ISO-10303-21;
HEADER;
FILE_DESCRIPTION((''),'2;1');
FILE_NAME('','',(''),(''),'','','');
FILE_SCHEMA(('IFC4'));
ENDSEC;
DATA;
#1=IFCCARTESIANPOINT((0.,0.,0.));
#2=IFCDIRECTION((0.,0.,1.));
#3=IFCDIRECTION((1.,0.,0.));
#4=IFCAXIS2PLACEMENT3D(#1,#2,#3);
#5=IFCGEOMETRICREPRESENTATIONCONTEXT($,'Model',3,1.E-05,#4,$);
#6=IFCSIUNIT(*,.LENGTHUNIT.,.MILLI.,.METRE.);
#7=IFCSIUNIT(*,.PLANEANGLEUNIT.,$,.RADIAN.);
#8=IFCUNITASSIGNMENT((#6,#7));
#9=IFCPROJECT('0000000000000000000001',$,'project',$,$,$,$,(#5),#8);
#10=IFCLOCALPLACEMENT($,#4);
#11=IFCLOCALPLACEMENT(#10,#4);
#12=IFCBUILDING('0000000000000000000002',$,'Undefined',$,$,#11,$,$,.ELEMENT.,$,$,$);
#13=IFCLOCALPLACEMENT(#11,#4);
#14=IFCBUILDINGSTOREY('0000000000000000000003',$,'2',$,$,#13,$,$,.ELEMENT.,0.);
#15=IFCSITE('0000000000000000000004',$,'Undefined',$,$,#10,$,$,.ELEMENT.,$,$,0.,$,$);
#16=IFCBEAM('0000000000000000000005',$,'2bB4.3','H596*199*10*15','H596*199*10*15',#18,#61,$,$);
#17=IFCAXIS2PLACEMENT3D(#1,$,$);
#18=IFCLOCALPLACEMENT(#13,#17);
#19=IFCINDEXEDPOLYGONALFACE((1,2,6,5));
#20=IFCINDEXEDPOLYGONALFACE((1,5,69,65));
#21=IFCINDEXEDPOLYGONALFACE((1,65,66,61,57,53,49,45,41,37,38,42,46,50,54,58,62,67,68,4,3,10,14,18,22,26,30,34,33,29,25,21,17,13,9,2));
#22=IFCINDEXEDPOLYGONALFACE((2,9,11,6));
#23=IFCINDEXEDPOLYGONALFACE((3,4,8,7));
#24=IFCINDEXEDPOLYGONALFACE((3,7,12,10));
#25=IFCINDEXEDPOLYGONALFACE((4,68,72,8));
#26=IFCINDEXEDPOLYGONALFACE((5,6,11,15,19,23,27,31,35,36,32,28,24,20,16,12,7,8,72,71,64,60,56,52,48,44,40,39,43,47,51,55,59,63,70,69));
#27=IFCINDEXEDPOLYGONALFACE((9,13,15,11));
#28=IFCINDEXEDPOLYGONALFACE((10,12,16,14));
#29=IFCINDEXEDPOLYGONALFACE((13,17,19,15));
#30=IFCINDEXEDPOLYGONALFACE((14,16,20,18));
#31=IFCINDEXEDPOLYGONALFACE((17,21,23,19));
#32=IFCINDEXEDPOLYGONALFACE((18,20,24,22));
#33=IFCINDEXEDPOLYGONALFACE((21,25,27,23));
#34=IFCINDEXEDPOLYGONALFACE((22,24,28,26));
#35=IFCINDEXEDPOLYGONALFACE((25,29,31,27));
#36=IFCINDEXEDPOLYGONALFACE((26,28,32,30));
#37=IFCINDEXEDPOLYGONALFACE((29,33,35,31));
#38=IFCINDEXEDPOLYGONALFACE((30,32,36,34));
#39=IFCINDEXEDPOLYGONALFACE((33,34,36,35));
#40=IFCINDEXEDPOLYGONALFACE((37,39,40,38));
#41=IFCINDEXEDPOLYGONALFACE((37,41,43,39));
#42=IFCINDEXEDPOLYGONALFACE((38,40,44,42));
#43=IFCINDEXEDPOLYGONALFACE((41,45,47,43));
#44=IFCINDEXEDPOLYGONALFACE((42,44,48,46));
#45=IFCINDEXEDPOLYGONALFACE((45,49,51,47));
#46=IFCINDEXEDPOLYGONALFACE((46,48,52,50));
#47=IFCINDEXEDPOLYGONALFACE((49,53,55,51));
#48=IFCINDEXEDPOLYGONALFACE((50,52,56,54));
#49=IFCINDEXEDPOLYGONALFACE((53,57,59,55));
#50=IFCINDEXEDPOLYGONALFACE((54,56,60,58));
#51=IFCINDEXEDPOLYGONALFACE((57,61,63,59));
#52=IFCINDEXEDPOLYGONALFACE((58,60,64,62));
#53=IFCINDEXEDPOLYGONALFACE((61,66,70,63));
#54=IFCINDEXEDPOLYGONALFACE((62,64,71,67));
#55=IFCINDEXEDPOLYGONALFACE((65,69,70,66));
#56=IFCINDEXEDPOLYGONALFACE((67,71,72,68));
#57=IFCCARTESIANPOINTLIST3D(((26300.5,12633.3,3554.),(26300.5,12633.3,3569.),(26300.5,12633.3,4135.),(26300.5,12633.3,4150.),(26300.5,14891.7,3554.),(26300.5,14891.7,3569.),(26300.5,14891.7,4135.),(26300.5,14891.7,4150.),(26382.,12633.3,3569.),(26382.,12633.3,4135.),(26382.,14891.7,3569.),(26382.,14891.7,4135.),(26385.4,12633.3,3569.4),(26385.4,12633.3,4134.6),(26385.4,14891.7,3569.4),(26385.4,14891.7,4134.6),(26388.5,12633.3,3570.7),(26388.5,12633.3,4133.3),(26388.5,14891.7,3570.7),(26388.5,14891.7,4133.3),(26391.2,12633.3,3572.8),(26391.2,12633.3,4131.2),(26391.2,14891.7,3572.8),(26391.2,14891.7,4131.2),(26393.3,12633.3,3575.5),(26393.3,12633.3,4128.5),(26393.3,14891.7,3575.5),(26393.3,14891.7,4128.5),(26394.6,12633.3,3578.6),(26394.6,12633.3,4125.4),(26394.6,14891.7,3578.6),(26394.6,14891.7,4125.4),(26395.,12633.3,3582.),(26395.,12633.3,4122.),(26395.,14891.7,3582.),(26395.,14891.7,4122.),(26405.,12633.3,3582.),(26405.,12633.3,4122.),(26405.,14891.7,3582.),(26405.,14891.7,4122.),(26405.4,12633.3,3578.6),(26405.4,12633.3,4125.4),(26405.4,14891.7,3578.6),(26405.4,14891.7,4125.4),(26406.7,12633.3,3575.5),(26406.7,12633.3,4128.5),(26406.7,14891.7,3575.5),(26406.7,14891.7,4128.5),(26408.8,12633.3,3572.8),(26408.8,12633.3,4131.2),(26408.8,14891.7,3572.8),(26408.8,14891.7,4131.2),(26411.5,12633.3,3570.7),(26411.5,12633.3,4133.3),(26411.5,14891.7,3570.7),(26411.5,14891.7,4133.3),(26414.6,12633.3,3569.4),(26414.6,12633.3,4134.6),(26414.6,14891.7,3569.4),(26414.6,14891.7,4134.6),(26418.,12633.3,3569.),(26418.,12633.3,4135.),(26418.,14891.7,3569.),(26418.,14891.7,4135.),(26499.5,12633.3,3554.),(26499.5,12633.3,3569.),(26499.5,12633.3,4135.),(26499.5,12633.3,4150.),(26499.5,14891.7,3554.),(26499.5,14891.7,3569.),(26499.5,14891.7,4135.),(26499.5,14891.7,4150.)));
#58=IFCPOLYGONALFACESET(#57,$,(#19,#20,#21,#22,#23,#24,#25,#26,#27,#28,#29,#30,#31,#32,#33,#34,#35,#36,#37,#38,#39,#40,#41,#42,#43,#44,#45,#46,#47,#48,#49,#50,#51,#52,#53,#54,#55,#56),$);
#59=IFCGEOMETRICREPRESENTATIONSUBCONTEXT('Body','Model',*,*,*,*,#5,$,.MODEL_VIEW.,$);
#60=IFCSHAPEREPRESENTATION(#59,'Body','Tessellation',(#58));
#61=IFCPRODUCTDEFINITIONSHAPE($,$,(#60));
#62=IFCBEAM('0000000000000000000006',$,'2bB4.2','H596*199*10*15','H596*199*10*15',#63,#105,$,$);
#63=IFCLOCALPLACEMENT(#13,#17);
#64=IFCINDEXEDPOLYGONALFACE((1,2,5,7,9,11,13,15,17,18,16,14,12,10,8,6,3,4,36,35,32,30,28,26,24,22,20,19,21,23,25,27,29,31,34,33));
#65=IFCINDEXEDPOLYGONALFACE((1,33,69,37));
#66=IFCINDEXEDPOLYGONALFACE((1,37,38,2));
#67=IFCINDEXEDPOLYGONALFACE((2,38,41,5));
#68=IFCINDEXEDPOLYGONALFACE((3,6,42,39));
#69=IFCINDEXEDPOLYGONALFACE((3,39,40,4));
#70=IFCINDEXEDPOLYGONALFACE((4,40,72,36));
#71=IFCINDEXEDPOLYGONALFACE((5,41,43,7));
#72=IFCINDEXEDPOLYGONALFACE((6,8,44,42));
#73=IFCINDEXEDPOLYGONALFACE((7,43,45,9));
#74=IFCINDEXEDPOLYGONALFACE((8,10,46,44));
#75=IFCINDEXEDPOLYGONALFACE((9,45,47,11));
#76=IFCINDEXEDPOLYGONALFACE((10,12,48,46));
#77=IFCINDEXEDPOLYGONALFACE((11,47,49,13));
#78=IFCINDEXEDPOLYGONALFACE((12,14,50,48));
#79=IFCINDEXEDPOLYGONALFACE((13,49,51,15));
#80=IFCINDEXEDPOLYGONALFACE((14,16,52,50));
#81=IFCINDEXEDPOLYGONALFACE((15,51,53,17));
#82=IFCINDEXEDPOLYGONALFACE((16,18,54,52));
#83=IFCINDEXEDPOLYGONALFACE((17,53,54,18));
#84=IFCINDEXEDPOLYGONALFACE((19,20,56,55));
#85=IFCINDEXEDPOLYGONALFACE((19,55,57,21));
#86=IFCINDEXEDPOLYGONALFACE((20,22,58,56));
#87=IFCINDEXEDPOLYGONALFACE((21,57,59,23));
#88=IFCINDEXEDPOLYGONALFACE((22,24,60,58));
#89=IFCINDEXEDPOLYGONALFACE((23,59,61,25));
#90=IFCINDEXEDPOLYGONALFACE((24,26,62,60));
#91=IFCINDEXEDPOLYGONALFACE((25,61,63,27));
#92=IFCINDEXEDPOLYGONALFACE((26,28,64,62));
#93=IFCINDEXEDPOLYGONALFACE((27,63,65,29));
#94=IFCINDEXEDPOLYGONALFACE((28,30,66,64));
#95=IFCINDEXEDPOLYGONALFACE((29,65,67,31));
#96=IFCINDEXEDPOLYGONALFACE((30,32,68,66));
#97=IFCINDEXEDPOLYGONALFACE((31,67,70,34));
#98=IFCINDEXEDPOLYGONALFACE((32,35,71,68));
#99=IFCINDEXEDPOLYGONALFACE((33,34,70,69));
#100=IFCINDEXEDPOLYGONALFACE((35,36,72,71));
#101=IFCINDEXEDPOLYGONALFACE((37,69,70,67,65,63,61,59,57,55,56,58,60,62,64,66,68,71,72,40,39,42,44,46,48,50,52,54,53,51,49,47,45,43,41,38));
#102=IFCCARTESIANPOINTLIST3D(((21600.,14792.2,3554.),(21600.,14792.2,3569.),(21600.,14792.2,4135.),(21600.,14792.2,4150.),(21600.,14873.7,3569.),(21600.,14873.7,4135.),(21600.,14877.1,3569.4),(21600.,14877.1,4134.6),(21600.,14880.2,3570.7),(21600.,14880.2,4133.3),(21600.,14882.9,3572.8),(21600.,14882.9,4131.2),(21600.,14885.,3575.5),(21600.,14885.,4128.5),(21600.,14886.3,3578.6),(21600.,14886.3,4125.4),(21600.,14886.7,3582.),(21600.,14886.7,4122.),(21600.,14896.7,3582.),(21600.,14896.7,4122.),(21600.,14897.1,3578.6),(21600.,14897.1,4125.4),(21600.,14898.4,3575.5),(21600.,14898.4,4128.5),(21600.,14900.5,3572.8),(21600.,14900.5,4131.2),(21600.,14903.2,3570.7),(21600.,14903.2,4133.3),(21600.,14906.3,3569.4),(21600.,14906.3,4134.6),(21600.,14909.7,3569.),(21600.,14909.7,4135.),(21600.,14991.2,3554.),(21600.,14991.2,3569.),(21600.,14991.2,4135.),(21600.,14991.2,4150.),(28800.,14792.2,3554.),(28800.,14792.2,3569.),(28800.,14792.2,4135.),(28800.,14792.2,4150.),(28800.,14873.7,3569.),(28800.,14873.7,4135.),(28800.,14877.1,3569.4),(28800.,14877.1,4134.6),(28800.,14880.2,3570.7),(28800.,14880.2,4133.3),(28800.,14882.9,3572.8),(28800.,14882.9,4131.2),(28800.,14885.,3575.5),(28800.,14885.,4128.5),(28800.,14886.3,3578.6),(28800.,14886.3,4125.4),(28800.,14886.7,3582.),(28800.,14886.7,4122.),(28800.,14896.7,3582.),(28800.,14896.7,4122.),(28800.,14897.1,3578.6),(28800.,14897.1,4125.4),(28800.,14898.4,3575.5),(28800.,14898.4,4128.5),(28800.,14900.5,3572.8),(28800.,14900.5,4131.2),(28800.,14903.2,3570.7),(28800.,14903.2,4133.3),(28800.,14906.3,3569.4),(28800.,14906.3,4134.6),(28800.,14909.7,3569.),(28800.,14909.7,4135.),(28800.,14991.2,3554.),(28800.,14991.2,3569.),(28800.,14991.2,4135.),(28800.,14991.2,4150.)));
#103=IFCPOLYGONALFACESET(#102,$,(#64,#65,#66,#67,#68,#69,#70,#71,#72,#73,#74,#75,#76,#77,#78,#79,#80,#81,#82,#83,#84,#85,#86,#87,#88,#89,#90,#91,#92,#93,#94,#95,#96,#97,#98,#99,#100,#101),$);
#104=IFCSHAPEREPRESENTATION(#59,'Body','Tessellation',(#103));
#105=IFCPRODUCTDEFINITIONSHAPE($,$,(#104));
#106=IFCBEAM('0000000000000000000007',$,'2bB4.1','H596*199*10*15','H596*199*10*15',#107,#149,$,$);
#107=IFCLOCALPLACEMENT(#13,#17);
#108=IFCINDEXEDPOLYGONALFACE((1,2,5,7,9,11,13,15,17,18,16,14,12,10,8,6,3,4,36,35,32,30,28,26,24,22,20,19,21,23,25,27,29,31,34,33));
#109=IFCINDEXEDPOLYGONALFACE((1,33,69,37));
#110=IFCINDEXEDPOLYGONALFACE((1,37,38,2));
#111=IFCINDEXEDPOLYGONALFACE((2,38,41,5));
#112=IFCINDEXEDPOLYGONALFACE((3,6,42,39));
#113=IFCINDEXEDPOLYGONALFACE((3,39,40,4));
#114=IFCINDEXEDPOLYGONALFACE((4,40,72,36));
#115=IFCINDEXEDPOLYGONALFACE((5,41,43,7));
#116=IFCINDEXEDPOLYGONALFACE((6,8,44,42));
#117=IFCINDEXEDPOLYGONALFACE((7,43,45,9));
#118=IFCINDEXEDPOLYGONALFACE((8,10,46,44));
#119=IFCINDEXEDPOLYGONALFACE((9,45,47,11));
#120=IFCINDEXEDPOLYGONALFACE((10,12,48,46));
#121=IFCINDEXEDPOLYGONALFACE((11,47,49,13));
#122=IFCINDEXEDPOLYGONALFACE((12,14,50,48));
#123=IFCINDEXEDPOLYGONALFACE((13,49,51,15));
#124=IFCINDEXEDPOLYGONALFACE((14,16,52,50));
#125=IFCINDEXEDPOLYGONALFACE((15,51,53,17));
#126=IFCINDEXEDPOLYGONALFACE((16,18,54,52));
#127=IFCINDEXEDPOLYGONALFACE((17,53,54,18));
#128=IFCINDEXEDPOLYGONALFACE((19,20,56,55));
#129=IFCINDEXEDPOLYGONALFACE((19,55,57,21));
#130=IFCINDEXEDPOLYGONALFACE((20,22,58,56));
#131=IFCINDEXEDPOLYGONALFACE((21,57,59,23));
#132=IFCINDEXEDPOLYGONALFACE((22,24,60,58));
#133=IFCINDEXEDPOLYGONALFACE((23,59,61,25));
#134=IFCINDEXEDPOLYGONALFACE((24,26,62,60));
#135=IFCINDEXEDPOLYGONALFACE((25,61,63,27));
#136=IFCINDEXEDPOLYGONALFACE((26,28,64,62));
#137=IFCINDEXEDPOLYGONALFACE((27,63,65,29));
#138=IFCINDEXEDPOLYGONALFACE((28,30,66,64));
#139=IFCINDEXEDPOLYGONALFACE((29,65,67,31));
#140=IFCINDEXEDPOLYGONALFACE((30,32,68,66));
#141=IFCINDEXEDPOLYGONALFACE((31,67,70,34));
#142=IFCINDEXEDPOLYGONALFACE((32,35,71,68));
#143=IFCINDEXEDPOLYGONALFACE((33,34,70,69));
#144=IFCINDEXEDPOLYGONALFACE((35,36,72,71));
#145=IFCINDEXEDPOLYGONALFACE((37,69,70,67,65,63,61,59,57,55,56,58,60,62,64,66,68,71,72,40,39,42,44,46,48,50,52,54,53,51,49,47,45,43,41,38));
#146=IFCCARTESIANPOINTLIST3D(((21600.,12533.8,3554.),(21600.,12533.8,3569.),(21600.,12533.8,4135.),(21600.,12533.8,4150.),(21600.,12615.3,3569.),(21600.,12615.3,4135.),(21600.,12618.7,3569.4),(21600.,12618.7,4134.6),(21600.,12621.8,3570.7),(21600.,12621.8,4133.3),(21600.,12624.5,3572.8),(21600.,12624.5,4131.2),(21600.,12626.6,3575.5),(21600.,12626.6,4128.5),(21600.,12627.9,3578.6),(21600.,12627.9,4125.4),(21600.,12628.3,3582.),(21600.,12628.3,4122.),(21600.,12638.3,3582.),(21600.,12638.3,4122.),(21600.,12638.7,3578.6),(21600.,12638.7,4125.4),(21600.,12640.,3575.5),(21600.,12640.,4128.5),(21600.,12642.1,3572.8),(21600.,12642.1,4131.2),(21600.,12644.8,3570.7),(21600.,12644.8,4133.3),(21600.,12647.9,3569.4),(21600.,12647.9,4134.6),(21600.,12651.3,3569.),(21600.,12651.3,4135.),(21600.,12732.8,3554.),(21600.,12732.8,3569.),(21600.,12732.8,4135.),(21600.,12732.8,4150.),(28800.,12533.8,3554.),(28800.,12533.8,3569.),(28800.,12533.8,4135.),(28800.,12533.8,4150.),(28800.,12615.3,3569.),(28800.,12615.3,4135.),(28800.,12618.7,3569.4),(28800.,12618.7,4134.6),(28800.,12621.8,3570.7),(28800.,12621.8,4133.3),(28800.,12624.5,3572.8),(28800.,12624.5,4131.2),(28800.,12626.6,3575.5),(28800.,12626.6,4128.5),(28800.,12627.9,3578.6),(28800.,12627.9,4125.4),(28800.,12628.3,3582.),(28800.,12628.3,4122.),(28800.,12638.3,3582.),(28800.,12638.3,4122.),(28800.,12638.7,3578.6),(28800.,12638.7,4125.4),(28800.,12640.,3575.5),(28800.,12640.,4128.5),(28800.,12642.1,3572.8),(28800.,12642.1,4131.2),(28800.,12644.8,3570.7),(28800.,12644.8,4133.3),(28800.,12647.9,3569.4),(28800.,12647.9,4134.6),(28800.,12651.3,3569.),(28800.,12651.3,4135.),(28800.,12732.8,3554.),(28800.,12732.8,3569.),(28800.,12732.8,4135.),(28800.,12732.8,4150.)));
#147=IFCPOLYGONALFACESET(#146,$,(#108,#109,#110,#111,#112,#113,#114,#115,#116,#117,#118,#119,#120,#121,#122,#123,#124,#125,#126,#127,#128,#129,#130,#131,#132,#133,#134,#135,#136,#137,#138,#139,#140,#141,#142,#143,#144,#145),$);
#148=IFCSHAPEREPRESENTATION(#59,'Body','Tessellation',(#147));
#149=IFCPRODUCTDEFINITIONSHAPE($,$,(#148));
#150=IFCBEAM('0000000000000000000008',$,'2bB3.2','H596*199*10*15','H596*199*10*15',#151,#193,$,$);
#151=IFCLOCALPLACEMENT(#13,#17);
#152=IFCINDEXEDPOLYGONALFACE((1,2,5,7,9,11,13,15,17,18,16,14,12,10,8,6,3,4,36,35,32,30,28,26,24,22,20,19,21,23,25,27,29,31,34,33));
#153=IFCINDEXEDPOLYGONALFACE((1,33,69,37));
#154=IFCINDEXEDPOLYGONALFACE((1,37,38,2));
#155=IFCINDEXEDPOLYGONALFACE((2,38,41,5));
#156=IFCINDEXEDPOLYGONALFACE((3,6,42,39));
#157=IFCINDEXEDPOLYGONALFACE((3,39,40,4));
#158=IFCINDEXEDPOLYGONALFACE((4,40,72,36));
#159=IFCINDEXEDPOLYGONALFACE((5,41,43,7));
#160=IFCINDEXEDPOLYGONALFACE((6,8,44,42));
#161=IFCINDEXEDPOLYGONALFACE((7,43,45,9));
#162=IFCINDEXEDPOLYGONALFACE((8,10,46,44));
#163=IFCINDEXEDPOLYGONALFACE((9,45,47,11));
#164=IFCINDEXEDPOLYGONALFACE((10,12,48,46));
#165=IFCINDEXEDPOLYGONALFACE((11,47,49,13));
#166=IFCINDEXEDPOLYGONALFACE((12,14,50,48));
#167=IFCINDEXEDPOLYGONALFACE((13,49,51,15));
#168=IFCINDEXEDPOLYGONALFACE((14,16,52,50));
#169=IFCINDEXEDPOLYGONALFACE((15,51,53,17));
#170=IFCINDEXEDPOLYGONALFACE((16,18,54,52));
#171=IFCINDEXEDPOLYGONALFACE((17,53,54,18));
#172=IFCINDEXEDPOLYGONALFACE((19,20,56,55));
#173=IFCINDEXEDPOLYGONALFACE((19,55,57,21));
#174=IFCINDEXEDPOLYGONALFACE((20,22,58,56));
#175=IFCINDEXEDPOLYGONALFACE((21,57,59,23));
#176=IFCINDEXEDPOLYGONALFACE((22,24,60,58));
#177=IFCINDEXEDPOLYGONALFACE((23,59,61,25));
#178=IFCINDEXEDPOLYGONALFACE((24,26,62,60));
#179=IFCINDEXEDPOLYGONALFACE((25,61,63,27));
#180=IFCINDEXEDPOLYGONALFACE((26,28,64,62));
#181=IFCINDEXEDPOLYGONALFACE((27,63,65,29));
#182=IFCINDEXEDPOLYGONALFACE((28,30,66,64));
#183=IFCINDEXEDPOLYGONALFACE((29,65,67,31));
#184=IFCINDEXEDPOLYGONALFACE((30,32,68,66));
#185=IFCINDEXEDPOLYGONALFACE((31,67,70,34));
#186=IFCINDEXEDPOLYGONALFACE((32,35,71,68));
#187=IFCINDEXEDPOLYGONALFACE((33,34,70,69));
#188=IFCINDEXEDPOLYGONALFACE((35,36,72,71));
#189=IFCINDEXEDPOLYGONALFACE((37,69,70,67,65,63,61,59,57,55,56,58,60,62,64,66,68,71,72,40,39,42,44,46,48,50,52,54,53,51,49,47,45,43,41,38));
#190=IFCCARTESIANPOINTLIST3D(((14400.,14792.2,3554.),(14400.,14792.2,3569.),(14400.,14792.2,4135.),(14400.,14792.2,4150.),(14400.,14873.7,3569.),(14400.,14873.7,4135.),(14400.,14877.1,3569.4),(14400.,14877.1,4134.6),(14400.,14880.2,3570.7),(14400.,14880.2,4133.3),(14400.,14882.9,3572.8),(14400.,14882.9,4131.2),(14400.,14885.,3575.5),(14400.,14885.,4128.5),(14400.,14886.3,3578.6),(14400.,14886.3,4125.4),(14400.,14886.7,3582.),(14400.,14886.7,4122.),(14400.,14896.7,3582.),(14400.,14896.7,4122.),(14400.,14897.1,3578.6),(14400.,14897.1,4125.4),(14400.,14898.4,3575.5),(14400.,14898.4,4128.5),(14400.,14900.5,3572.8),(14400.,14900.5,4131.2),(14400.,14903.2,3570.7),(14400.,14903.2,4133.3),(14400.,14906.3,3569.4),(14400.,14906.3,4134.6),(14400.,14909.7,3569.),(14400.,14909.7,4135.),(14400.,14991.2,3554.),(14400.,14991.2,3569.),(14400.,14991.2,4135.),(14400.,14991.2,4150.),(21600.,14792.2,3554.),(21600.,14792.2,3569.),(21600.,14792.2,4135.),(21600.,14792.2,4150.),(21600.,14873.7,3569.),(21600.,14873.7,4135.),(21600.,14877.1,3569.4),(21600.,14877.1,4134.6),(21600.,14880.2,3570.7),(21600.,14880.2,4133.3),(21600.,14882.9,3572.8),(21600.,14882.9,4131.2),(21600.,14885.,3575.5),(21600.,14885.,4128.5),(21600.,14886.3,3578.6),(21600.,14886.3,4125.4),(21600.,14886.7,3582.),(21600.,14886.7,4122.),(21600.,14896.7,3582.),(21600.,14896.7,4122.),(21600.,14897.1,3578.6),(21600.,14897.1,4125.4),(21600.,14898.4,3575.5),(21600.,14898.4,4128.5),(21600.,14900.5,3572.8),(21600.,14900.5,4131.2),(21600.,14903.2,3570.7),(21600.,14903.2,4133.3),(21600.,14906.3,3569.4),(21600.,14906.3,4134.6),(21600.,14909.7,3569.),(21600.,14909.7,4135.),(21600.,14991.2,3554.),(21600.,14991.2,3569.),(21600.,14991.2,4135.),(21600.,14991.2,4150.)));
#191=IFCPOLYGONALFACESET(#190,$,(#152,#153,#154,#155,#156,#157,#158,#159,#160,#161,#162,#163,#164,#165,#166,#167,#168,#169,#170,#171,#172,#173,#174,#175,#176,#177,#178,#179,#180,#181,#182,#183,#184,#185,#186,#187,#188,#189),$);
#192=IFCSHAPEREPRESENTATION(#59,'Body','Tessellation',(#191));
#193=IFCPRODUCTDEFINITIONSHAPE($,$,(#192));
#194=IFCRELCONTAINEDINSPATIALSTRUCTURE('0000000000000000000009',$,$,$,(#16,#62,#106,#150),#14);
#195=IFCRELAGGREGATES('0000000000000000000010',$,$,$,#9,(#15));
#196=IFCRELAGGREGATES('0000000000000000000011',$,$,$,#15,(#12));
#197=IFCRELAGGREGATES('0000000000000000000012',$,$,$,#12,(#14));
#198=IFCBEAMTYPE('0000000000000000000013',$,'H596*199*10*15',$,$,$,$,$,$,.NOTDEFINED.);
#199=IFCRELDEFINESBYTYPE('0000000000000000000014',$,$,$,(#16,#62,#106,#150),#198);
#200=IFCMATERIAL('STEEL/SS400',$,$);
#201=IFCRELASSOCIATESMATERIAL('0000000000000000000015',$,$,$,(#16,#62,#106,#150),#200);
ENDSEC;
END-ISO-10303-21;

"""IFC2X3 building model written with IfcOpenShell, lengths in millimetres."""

from ifc_helpers import new_model, si_unit, frame, origin_with_axes, origin_2d_with_axis, place, context, subcontext, project, spatial, i_section, extrude, material, type_object, element, save


model = new_model("IFC2X3")

# Units and contexts
model_context = context("Model", 3, precision=1e-05, world=origin_with_axes())
body_context = subcontext(model_context, "Body", "Model", "MODEL_VIEW")
ifc_project = project(units=[si_unit("LENGTHUNIT", "METRE", prefix="MILLI"), si_unit("PLANEANGLEUNIT", "RADIAN")], contexts=[model_context])

# Site, building, storey
site_placement = place(None, origin_with_axes())
site = spatial("IfcSite", under=ifc_project, at=site_placement, Name="Undefined", CompositionType="ELEMENT", RefElevation=0.0)
building_placement = place(site_placement, origin_with_axes())
building = spatial("IfcBuilding", under=site, at=building_placement, Name="Undefined", CompositionType="ELEMENT")
storey_placement = place(building_placement, origin_with_axes())
storey = spatial("IfcBuildingStorey", under=building, at=storey_placement, Name="2", CompositionType="ELEMENT", Elevation=0.0)

# Beams
ifc_material_1 = material(Name="STEEL/SS400")
beam_type_1 = type_object("IfcBeamType", Name="H596*199*10*15", PredefinedType="NOTDEFINED")
beam_placement = place(storey_placement, frame((26400.0, 12633.3, 3852.0), z_axis=(0.0, 0.0, 1.0), x_axis=(0.0, 1.0, 0.0)))
element("IfcBeam", 1, at=beam_placement, inside=storey, type_object=beam_type_1, material=ifc_material_1, Name="2bB4.3", Description="H596*199*10*15", ObjectType="H596*199*10*15", context=body_context, shape_type="SweptSolid", body=[
    extrude(i_section(OverallWidth=199.0, OverallDepth=596.0, WebThickness=10.0, FlangeThickness=15.0, FilletRadius=13.0, at=origin_2d_with_axis()), frame((2258.4, 0.0, 0.0), z_axis=(-1.0, 0.0, 0.0), x_axis=(0.0, -1.0, 0.0)), (0.0, 0.0, 1.0), 2258.4),
])
for number, where, z_axis, x_axis, name in (
    (2, (21600.0, 14891.7, 3852.0), (0.0, 0.0, 1.0), (1.0, 0.0, 0.0), "2bB4.2"),
    (3, (21600.0, 12633.3, 3852.0), (0.0, 0.0, 1.0), (1.0, 0.0, 0.0), "2bB4.1"),
    (4, (14400.0, 14891.7, 3852.0), (0.0, 0.0, 1.0), (1.0, 0.0, 0.0), "2bB3.2"),
):
    element("IfcBeam", number, at=place(storey_placement, frame(where, z_axis=z_axis, x_axis=x_axis)), inside=storey, type_object=beam_type_1, material=ifc_material_1, Name=name, Description="H596*199*10*15", ObjectType="H596*199*10*15", context=body_context, shape_type="SweptSolid", body=[
        extrude(i_section(OverallWidth=199.0, OverallDepth=596.0, WebThickness=10.0, FlangeThickness=15.0, FilletRadius=13.0, at=origin_2d_with_axis()), frame((7200.0, 0.0, 0.0), z_axis=(-1.0, 0.0, 0.0), x_axis=(0.0, -1.0, 0.0)), (0.0, 0.0, 1.0), 7200.0),
    ])

save(model, "model.ifc")
